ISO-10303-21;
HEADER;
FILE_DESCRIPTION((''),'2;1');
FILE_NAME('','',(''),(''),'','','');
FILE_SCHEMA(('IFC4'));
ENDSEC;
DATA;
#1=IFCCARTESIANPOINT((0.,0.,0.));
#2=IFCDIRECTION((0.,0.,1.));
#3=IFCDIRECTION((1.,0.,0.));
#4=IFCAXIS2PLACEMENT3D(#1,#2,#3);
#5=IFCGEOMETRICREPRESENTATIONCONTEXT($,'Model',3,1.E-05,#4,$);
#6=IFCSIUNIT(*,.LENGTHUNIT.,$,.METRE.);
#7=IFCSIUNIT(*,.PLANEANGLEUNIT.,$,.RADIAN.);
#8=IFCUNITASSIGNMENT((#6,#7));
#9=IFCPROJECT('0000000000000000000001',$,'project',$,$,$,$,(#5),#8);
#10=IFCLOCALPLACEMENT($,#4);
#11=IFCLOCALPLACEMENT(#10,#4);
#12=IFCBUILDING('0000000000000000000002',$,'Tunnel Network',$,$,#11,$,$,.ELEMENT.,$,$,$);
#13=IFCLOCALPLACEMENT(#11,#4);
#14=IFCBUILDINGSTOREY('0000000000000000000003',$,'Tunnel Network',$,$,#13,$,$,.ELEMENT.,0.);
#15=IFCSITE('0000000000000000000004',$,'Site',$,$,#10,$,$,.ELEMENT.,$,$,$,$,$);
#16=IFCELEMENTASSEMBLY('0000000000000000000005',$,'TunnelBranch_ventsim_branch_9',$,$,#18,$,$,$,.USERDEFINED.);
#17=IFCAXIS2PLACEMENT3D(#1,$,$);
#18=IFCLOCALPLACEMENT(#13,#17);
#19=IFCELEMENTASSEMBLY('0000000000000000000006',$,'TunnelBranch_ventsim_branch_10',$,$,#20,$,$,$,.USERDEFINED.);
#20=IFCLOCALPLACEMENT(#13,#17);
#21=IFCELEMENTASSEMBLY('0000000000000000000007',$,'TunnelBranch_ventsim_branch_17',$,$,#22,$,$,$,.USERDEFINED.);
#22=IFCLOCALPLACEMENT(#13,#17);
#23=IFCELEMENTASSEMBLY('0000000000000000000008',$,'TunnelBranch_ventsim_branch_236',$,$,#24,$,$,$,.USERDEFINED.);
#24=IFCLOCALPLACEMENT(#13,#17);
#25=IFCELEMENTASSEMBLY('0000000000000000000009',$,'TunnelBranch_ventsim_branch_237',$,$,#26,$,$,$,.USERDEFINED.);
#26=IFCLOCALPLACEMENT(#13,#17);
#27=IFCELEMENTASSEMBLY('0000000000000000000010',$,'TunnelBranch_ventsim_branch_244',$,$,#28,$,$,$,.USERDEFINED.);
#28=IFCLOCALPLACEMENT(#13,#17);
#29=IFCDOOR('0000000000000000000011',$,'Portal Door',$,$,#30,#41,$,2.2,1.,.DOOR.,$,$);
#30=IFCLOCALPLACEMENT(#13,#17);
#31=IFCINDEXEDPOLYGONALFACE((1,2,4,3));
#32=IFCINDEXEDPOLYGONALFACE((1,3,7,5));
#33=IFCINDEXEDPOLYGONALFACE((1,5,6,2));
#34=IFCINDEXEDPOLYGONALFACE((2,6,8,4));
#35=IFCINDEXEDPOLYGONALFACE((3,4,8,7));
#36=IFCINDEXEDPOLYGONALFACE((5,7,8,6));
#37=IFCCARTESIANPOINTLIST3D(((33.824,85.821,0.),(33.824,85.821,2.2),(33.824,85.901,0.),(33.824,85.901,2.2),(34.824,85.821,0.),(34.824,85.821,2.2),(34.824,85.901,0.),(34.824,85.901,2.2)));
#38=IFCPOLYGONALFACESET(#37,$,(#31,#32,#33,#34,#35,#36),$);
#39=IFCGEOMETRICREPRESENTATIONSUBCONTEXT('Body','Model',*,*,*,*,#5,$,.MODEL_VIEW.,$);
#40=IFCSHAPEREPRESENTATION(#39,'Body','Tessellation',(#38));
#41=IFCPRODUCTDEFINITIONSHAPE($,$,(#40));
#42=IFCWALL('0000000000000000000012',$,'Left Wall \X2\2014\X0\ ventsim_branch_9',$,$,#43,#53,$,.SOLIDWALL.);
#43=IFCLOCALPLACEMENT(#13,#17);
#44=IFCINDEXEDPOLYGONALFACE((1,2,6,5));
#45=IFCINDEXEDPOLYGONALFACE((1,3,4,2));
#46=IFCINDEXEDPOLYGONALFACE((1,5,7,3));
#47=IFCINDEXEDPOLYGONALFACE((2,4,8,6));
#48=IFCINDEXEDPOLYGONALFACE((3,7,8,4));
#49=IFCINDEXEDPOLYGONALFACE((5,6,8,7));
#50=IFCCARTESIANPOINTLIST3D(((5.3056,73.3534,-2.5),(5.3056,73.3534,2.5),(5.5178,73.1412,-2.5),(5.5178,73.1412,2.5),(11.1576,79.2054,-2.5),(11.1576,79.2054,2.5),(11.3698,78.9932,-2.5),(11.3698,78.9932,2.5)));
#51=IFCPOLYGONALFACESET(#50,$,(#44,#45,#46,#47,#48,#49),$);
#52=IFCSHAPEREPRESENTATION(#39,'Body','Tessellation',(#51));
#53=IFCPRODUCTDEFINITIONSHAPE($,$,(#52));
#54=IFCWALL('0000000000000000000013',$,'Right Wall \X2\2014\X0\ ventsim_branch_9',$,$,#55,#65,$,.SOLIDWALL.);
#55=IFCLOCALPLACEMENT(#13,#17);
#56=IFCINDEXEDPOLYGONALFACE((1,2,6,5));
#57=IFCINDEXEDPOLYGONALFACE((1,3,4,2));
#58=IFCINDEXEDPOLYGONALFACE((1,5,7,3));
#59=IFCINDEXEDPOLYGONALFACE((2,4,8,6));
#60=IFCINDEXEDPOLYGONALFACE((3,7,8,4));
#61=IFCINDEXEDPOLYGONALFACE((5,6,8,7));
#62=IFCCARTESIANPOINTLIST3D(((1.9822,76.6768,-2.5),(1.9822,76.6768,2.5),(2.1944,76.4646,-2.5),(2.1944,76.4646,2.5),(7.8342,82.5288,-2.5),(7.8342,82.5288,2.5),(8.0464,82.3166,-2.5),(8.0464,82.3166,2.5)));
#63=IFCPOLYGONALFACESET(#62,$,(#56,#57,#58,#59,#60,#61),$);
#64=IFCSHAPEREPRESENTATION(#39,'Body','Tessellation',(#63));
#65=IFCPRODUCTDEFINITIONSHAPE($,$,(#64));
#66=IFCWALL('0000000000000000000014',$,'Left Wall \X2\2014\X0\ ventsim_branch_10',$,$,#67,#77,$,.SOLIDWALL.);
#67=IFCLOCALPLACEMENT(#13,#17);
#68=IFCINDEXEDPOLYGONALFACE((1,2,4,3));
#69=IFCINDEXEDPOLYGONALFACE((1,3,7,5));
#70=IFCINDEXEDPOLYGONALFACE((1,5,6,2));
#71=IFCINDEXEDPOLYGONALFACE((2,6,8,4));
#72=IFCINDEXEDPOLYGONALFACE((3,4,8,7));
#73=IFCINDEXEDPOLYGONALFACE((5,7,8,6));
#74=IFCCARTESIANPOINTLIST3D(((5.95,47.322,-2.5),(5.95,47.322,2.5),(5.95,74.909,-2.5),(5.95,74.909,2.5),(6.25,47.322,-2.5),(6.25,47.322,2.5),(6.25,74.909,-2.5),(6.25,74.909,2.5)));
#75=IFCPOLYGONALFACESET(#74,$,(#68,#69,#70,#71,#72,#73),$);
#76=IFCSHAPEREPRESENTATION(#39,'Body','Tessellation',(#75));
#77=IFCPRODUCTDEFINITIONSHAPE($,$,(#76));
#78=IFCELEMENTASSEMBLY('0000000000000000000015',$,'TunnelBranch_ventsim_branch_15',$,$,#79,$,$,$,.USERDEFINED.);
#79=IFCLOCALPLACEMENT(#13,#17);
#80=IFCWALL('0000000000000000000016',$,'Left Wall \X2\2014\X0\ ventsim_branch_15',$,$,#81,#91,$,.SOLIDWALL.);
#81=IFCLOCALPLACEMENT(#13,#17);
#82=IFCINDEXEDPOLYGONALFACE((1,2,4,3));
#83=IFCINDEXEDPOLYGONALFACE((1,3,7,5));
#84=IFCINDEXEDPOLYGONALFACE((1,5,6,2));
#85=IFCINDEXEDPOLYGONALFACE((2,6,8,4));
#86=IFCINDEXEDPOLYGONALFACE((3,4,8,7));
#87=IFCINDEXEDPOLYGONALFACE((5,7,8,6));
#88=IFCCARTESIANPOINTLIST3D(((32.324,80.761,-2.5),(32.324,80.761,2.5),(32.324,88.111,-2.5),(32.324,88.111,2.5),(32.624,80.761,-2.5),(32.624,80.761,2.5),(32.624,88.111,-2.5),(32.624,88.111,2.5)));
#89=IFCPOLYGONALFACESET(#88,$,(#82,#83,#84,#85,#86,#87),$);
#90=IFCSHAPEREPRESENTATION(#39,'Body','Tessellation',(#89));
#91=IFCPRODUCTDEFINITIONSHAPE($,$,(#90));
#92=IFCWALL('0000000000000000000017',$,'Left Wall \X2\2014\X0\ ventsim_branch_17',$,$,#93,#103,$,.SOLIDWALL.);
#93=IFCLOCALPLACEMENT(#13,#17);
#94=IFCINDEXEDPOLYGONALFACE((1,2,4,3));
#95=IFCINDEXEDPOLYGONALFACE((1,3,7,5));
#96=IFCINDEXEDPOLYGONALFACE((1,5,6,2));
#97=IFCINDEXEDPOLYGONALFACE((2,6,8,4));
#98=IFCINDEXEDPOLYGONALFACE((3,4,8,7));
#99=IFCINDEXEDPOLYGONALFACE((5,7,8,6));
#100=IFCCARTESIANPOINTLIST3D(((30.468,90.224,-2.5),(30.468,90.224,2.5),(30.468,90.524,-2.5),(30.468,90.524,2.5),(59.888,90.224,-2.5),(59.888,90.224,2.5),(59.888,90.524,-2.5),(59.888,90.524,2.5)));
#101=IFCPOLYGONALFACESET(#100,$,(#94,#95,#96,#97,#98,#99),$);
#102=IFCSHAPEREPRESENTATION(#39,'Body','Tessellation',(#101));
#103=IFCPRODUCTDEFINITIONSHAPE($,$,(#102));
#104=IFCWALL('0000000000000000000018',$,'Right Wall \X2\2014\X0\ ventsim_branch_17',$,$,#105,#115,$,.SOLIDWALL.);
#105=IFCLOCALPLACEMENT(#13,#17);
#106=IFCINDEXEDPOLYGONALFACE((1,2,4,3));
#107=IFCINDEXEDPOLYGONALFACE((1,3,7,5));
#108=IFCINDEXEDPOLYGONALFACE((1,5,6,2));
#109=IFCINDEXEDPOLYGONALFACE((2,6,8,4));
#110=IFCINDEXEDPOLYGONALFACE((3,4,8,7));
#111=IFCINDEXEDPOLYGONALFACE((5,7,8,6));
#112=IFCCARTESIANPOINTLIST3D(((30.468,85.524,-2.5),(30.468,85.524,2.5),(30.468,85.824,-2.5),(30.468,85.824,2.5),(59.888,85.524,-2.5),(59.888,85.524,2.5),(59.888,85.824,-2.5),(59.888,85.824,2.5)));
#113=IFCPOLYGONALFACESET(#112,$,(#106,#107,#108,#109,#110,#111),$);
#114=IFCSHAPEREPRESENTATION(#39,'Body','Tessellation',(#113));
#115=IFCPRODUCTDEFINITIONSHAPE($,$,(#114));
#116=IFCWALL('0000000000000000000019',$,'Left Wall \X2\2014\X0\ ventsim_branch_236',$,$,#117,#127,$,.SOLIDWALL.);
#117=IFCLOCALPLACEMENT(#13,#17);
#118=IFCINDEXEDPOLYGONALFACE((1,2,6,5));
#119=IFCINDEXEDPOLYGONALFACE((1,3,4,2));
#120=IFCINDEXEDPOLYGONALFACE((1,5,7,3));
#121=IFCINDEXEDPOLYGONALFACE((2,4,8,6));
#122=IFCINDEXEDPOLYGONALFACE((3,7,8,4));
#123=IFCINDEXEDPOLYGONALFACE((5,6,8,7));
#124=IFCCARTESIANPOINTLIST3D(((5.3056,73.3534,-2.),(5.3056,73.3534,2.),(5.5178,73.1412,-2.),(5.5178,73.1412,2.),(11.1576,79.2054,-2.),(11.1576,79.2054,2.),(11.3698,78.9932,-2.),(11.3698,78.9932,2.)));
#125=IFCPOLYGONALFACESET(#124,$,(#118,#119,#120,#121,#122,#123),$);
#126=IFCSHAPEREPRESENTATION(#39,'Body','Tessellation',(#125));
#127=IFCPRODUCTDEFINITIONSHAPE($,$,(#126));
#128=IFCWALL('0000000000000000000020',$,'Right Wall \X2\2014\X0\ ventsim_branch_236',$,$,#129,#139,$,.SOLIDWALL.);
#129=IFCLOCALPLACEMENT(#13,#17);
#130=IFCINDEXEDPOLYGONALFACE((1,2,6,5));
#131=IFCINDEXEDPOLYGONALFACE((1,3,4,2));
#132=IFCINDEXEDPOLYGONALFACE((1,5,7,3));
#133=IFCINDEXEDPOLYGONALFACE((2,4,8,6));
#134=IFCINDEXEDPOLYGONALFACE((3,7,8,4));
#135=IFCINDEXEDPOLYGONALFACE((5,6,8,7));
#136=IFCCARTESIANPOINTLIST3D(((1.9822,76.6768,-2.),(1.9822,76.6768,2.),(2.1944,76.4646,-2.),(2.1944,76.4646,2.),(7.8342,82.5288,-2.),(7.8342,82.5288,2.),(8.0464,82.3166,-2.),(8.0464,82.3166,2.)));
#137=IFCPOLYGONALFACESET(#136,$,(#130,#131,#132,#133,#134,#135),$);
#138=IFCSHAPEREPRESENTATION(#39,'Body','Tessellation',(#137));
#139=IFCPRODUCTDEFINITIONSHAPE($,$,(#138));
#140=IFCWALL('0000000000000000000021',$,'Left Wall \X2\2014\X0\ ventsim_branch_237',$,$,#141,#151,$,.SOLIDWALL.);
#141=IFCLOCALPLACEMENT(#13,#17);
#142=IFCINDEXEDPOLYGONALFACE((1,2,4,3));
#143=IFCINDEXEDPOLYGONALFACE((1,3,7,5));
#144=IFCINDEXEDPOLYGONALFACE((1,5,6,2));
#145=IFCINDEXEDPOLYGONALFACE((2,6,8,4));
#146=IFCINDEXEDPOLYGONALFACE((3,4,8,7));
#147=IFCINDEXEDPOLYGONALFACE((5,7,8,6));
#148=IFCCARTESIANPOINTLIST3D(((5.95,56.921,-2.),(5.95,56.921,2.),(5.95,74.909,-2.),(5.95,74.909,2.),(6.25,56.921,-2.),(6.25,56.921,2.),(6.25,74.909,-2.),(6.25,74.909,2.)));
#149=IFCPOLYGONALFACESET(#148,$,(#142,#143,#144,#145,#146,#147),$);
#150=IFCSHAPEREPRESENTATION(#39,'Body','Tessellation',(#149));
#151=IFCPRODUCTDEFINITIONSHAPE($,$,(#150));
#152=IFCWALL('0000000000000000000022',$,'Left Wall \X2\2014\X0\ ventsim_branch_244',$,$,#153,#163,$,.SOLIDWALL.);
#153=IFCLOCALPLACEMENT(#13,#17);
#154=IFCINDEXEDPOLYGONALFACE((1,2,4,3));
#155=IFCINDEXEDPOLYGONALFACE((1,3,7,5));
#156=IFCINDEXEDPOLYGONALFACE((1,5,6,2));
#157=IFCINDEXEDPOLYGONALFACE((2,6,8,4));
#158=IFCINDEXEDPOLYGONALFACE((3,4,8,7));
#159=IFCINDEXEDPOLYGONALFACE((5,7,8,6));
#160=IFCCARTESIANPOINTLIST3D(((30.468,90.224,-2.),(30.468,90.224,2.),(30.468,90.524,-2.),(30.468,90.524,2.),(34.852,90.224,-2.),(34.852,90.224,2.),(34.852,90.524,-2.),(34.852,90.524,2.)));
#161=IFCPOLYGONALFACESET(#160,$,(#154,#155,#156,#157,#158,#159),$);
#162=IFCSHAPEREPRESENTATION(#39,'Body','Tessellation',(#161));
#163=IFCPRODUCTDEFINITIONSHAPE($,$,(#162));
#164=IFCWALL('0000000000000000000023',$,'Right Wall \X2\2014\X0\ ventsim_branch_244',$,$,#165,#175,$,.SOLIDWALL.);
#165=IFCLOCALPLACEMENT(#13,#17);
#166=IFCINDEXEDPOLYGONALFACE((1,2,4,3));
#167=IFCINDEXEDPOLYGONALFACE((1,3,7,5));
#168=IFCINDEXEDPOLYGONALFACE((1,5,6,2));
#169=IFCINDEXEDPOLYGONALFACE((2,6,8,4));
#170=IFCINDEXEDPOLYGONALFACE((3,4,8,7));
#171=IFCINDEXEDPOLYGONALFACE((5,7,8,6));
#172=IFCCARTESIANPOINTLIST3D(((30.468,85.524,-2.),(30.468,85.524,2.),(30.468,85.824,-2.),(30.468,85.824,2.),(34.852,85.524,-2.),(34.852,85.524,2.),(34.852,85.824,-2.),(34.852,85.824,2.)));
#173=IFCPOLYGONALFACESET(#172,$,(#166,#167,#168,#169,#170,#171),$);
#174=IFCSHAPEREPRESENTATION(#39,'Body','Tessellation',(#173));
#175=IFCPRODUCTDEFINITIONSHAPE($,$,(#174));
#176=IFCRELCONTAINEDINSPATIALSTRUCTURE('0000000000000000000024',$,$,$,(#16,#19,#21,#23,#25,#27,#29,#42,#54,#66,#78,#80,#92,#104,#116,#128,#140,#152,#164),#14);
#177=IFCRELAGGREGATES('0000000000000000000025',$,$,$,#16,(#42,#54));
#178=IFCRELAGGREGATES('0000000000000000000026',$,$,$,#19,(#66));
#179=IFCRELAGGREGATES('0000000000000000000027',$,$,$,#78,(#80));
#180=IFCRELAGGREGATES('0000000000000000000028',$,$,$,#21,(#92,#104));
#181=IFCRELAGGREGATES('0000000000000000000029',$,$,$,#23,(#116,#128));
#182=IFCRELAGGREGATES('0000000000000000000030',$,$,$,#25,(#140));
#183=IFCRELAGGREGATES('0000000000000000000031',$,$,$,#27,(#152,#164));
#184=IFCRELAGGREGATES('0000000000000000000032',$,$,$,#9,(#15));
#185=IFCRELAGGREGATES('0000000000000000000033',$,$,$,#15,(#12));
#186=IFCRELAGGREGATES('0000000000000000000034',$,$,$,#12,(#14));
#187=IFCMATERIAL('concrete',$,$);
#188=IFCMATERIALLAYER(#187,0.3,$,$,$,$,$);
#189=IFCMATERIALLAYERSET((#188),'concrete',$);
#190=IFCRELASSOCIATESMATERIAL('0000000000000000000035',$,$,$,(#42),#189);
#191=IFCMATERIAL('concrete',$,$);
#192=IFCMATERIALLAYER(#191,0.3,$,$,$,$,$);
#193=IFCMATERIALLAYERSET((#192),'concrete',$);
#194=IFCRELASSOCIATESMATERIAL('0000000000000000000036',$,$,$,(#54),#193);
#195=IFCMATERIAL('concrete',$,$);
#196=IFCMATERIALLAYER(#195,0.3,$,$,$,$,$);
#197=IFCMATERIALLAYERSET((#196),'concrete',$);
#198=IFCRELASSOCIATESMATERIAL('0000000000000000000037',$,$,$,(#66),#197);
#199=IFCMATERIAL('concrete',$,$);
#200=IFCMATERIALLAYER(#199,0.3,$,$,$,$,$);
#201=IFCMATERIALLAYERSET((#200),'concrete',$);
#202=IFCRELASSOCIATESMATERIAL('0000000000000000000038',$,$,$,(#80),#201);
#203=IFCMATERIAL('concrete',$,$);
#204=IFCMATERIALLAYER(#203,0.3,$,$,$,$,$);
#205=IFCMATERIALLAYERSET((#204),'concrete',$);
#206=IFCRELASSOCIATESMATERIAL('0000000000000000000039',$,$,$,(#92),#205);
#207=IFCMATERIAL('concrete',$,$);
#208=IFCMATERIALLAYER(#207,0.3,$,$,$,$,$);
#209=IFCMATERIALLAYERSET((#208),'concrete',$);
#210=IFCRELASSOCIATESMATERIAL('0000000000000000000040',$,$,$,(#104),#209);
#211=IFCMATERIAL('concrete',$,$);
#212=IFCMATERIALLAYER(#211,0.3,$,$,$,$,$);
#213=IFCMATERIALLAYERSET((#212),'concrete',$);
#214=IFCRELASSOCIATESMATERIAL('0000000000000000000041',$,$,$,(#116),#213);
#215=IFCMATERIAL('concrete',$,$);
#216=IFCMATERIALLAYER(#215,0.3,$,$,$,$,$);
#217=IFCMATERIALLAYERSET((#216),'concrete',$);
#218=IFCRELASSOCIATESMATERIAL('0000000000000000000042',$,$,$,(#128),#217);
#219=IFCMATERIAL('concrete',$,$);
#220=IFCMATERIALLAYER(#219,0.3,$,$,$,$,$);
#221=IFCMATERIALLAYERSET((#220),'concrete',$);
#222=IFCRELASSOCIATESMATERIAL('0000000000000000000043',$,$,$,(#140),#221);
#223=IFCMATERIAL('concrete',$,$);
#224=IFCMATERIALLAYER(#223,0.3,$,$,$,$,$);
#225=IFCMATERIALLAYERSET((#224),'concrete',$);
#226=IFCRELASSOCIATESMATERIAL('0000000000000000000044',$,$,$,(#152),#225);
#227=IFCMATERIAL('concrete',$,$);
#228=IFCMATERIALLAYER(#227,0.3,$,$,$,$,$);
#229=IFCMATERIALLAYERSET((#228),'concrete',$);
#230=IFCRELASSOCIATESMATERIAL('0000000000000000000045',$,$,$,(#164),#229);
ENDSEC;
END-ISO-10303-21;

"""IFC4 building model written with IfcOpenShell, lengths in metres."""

from ifc_helpers import new_model, si_unit, frame, origin_with_axes, origin_2d_with_axis, place, context, subcontext, project, spatial, rectangle, extrude, material, layer, layer_set, layer_usage, element, aggregate, save


model = new_model("IFC4")

# Units and contexts
model_context = context("Model", 3, precision=1e-05, world=origin_with_axes())
body_context = subcontext(model_context, "Body", "Model", "MODEL_VIEW")
ifc_project = project(units=[si_unit("LENGTHUNIT", "METRE"), si_unit("PLANEANGLEUNIT", "RADIAN")], contexts=[model_context])

# Site, building, storey
site_placement = place(None, origin_with_axes())
site = spatial("IfcSite", under=ifc_project, at=site_placement, Name="Site", CompositionType="ELEMENT")
building_placement = place(site_placement, origin_with_axes())
building = spatial("IfcBuilding", under=site, at=building_placement, Name="Tunnel Network", CompositionType="ELEMENT")
storey_placement = place(building_placement, origin_with_axes())
storey = spatial("IfcBuildingStorey", under=building, at=storey_placement, Name="Tunnel Network", CompositionType="ELEMENT", Elevation=0.0)

# Element assemblies
assembly_1_placement = place(storey_placement, frame((11.2637, 79.0993, 0.0), z_axis=(-0.707107, -0.707106, 0.0), x_axis=(-0.707106, 0.707107, 0.0)))
assembly_1 = element("IfcElementAssembly", 1, at=assembly_1_placement, inside=storey, Name="TunnelBranch_ventsim_branch_9", PredefinedType="USERDEFINED")
assembly_2_placement = place(storey_placement, frame((6.1, 74.909, 0.0), z_axis=(0.0, -1.0, 0.0), x_axis=(-1.0, 0.0, 0.0)))
assembly_2 = element("IfcElementAssembly", 2, at=assembly_2_placement, inside=storey, Name="TunnelBranch_ventsim_branch_10", PredefinedType="USERDEFINED")
assembly_3_placement = place(storey_placement, frame((30.468, 90.374, 0.0), z_axis=(1.0, 0.0, 0.0), x_axis=(0.0, -1.0, 0.0)))
assembly_3 = element("IfcElementAssembly", 3, at=assembly_3_placement, inside=storey, Name="TunnelBranch_ventsim_branch_17", PredefinedType="USERDEFINED")
assembly_4_placement = place(storey_placement, frame((11.2637, 79.0993, 0.0), z_axis=(-0.707107, -0.707106, 0.0), x_axis=(-0.707106, 0.707107, 0.0)))
assembly_4 = element("IfcElementAssembly", 4, at=assembly_4_placement, inside=storey, Name="TunnelBranch_ventsim_branch_236", PredefinedType="USERDEFINED")
assembly_5_placement = place(storey_placement, frame((6.1, 74.909, 0.0), z_axis=(0.0, -1.0, 0.0), x_axis=(-1.0, 0.0, 0.0)))
assembly_5 = element("IfcElementAssembly", 5, at=assembly_5_placement, inside=storey, Name="TunnelBranch_ventsim_branch_237", PredefinedType="USERDEFINED")
assembly_6_placement = place(storey_placement, frame((30.468, 90.374, 0.0), z_axis=(1.0, 0.0, 0.0), x_axis=(0.0, -1.0, 0.0)))
assembly_6 = element("IfcElementAssembly", 6, at=assembly_6_placement, inside=storey, Name="TunnelBranch_ventsim_branch_244", PredefinedType="USERDEFINED")

# Door
door_placement = place(storey_placement, frame((34.324, 85.861, 0.0), z_axis=(0.0, 0.0, 1.0), x_axis=(1.0, 0.0, 0.0)))
element("IfcDoor", 7, at=door_placement, inside=storey, Name="Portal Door", OverallHeight=2.2, OverallWidth=1.0, PredefinedType="DOOR", context=body_context, shape_type="SweptSolid", body=[
    extrude(rectangle(XDim=1.0, YDim=0.08, at=origin_2d_with_axis()), origin_with_axes(), (0.0, 0.0, 1.0), 2.2),
])

# Walls
ifc_material_1 = material(Name="concrete")
ifc_layer_1 = layer(ifc_material_1, 0.3)
ifc_layer_set_1 = layer_set([ifc_layer_1], Name="concrete")
ifc_layer_usage_1 = layer_usage(ifc_layer_set_1, "AXIS2", "POSITIVE", 0.0)
wall_1_placement = place(storey_placement, frame((11.2637, 79.0993, 0.0), z_axis=(-0.707107, -0.707106, 0.0), x_axis=(-0.707106, 0.707107, 0.0)))
wall_1 = element("IfcWall", 8, at=wall_1_placement, inside=storey, material=ifc_layer_usage_1, Name="Left Wall — ventsim_branch_9", PredefinedType="SOLIDWALL", context=body_context, shape_type="SweptSolid", body=[
    extrude(rectangle(XDim=0.3, YDim=5.0, at=origin_2d_with_axis()), origin_with_axes(), (0.0, 0.0, 1.0), 8.276),
])
ifc_material_2 = material(Name="concrete")
ifc_layer_2 = layer(ifc_material_2, 0.3)
ifc_layer_set_2 = layer_set([ifc_layer_2], Name="concrete")
ifc_layer_usage_2 = layer_usage(ifc_layer_set_2, "AXIS2", "POSITIVE", 0.0)
wall_2_placement = place(storey_placement, frame((7.9403, 82.4227, 0.0), z_axis=(-0.707107, -0.707106, 0.0), x_axis=(-0.707106, 0.707107, 0.0)))
wall_2 = element("IfcWall", 9, at=wall_2_placement, inside=storey, material=ifc_layer_usage_2, Name="Right Wall — ventsim_branch_9", PredefinedType="SOLIDWALL", context=body_context, shape_type="SweptSolid", body=[
    extrude(rectangle(XDim=0.3, YDim=5.0, at=origin_2d_with_axis()), origin_with_axes(), (0.0, 0.0, 1.0), 8.276),
])
aggregate(assembly_1, [wall_1, wall_2])
ifc_material_3 = material(Name="concrete")
ifc_layer_3 = layer(ifc_material_3, 0.3)
ifc_layer_set_3 = layer_set([ifc_layer_3], Name="concrete")
ifc_layer_usage_3 = layer_usage(ifc_layer_set_3, "AXIS2", "POSITIVE", 0.0)
wall_3_placement = place(storey_placement, frame((6.1, 74.909, 0.0), z_axis=(0.0, -1.0, 0.0), x_axis=(-1.0, 0.0, 0.0)))
wall_3 = element("IfcWall", 10, at=wall_3_placement, inside=storey, material=ifc_layer_usage_3, Name="Left Wall — ventsim_branch_10", PredefinedType="SOLIDWALL", context=body_context, shape_type="SweptSolid", body=[
    extrude(rectangle(XDim=0.3, YDim=5.0, at=origin_2d_with_axis()), origin_with_axes(), (0.0, 0.0, 1.0), 27.587),
])
aggregate(assembly_2, [wall_3])

# Element assembly, wall
assembly_7_placement = place(storey_placement, frame((32.474, 80.761, 0.0), z_axis=(0.0, 1.0, 0.0), x_axis=(1.0, 0.0, 0.0)))
assembly_7 = element("IfcElementAssembly", 11, at=assembly_7_placement, inside=storey, Name="TunnelBranch_ventsim_branch_15", PredefinedType="USERDEFINED")
ifc_material_4 = material(Name="concrete")
ifc_layer_4 = layer(ifc_material_4, 0.3)
ifc_layer_set_4 = layer_set([ifc_layer_4], Name="concrete")
ifc_layer_usage_4 = layer_usage(ifc_layer_set_4, "AXIS2", "POSITIVE", 0.0)
wall_4_placement = place(storey_placement, frame((32.474, 80.761, 0.0), z_axis=(0.0, 1.0, 0.0), x_axis=(1.0, 0.0, 0.0)))
wall_4 = element("IfcWall", 12, at=wall_4_placement, inside=storey, material=ifc_layer_usage_4, Name="Left Wall — ventsim_branch_15", PredefinedType="SOLIDWALL", context=body_context, shape_type="SweptSolid", body=[
    extrude(rectangle(XDim=0.3, YDim=5.0, at=origin_2d_with_axis()), origin_with_axes(), (0.0, 0.0, 1.0), 7.35),
])
aggregate(assembly_7, [wall_4])

# Walls
ifc_material_5 = material(Name="concrete")
ifc_layer_5 = layer(ifc_material_5, 0.3)
ifc_layer_set_5 = layer_set([ifc_layer_5], Name="concrete")
ifc_layer_usage_5 = layer_usage(ifc_layer_set_5, "AXIS2", "POSITIVE", 0.0)
wall_5_placement = place(storey_placement, frame((30.468, 90.374, 0.0), z_axis=(1.0, 0.0, 0.0), x_axis=(0.0, -1.0, 0.0)))
wall_5 = element("IfcWall", 13, at=wall_5_placement, inside=storey, material=ifc_layer_usage_5, Name="Left Wall — ventsim_branch_17", PredefinedType="SOLIDWALL", context=body_context, shape_type="SweptSolid", body=[
    extrude(rectangle(XDim=0.3, YDim=5.0, at=origin_2d_with_axis()), origin_with_axes(), (0.0, 0.0, 1.0), 29.42),
])
ifc_material_6 = material(Name="concrete")
ifc_layer_6 = layer(ifc_material_6, 0.3)
ifc_layer_set_6 = layer_set([ifc_layer_6], Name="concrete")
ifc_layer_usage_6 = layer_usage(ifc_layer_set_6, "AXIS2", "POSITIVE", 0.0)
wall_6_placement = place(storey_placement, frame((30.468, 85.674, 0.0), z_axis=(1.0, 0.0, 0.0), x_axis=(0.0, -1.0, 0.0)))
wall_6 = element("IfcWall", 14, at=wall_6_placement, inside=storey, material=ifc_layer_usage_6, Name="Right Wall — ventsim_branch_17", PredefinedType="SOLIDWALL", context=body_context, shape_type="SweptSolid", body=[
    extrude(rectangle(XDim=0.3, YDim=5.0, at=origin_2d_with_axis()), origin_with_axes(), (0.0, 0.0, 1.0), 29.42),
])
aggregate(assembly_3, [wall_5, wall_6])
ifc_material_7 = material(Name="concrete")
ifc_layer_7 = layer(ifc_material_7, 0.3)
ifc_layer_set_7 = layer_set([ifc_layer_7], Name="concrete")
ifc_layer_usage_7 = layer_usage(ifc_layer_set_7, "AXIS2", "POSITIVE", 0.0)
wall_7_placement = place(storey_placement, frame((11.2637, 79.0993, 0.0), z_axis=(-0.707107, -0.707106, 0.0), x_axis=(-0.707106, 0.707107, 0.0)))
wall_7 = element("IfcWall", 15, at=wall_7_placement, inside=storey, material=ifc_layer_usage_7, Name="Left Wall — ventsim_branch_236", PredefinedType="SOLIDWALL", context=body_context, shape_type="SweptSolid", body=[
    extrude(rectangle(XDim=0.3, YDim=4.0, at=origin_2d_with_axis()), origin_with_axes(), (0.0, 0.0, 1.0), 8.276),
])
ifc_material_8 = material(Name="concrete")
ifc_layer_8 = layer(ifc_material_8, 0.3)
ifc_layer_set_8 = layer_set([ifc_layer_8], Name="concrete")
ifc_layer_usage_8 = layer_usage(ifc_layer_set_8, "AXIS2", "POSITIVE", 0.0)
wall_8_placement = place(storey_placement, frame((7.9403, 82.4227, 0.0), z_axis=(-0.707107, -0.707106, 0.0), x_axis=(-0.707106, 0.707107, 0.0)))
wall_8 = element("IfcWall", 16, at=wall_8_placement, inside=storey, material=ifc_layer_usage_8, Name="Right Wall — ventsim_branch_236", PredefinedType="SOLIDWALL", context=body_context, shape_type="SweptSolid", body=[
    extrude(rectangle(XDim=0.3, YDim=4.0, at=origin_2d_with_axis()), origin_with_axes(), (0.0, 0.0, 1.0), 8.276),
])
aggregate(assembly_4, [wall_7, wall_8])
ifc_material_9 = material(Name="concrete")
ifc_layer_9 = layer(ifc_material_9, 0.3)
ifc_layer_set_9 = layer_set([ifc_layer_9], Name="concrete")
ifc_layer_usage_9 = layer_usage(ifc_layer_set_9, "AXIS2", "POSITIVE", 0.0)
wall_9_placement = place(storey_placement, frame((6.1, 74.909, 0.0), z_axis=(0.0, -1.0, 0.0), x_axis=(-1.0, 0.0, 0.0)))
wall_9 = element("IfcWall", 17, at=wall_9_placement, inside=storey, material=ifc_layer_usage_9, Name="Left Wall — ventsim_branch_237", PredefinedType="SOLIDWALL", context=body_context, shape_type="SweptSolid", body=[
    extrude(rectangle(XDim=0.3, YDim=4.0, at=origin_2d_with_axis()), origin_with_axes(), (0.0, 0.0, 1.0), 17.988),
])
aggregate(assembly_5, [wall_9])
ifc_material_10 = material(Name="concrete")
ifc_layer_10 = layer(ifc_material_10, 0.3)
ifc_layer_set_10 = layer_set([ifc_layer_10], Name="concrete")
ifc_layer_usage_10 = layer_usage(ifc_layer_set_10, "AXIS2", "POSITIVE", 0.0)
wall_10_placement = place(storey_placement, frame((30.468, 90.374, 0.0), z_axis=(1.0, 0.0, 0.0), x_axis=(0.0, -1.0, 0.0)))
wall_10 = element("IfcWall", 18, at=wall_10_placement, inside=storey, material=ifc_layer_usage_10, Name="Left Wall — ventsim_branch_244", PredefinedType="SOLIDWALL", context=body_context, shape_type="SweptSolid", body=[
    extrude(rectangle(XDim=0.3, YDim=4.0, at=origin_2d_with_axis()), origin_with_axes(), (0.0, 0.0, 1.0), 4.384),
])
ifc_material_11 = material(Name="concrete")
ifc_layer_11 = layer(ifc_material_11, 0.3)
ifc_layer_set_11 = layer_set([ifc_layer_11], Name="concrete")
ifc_layer_usage_11 = layer_usage(ifc_layer_set_11, "AXIS2", "POSITIVE", 0.0)
wall_11_placement = place(storey_placement, frame((30.468, 85.674, 0.0), z_axis=(1.0, 0.0, 0.0), x_axis=(0.0, -1.0, 0.0)))
wall_11 = element("IfcWall", 19, at=wall_11_placement, inside=storey, material=ifc_layer_usage_11, Name="Right Wall — ventsim_branch_244", PredefinedType="SOLIDWALL", context=body_context, shape_type="SweptSolid", body=[
    extrude(rectangle(XDim=0.3, YDim=4.0, at=origin_2d_with_axis()), origin_with_axes(), (0.0, 0.0, 1.0), 4.384),
])
aggregate(assembly_6, [wall_10, wall_11])

save(model, "model.ifc")
